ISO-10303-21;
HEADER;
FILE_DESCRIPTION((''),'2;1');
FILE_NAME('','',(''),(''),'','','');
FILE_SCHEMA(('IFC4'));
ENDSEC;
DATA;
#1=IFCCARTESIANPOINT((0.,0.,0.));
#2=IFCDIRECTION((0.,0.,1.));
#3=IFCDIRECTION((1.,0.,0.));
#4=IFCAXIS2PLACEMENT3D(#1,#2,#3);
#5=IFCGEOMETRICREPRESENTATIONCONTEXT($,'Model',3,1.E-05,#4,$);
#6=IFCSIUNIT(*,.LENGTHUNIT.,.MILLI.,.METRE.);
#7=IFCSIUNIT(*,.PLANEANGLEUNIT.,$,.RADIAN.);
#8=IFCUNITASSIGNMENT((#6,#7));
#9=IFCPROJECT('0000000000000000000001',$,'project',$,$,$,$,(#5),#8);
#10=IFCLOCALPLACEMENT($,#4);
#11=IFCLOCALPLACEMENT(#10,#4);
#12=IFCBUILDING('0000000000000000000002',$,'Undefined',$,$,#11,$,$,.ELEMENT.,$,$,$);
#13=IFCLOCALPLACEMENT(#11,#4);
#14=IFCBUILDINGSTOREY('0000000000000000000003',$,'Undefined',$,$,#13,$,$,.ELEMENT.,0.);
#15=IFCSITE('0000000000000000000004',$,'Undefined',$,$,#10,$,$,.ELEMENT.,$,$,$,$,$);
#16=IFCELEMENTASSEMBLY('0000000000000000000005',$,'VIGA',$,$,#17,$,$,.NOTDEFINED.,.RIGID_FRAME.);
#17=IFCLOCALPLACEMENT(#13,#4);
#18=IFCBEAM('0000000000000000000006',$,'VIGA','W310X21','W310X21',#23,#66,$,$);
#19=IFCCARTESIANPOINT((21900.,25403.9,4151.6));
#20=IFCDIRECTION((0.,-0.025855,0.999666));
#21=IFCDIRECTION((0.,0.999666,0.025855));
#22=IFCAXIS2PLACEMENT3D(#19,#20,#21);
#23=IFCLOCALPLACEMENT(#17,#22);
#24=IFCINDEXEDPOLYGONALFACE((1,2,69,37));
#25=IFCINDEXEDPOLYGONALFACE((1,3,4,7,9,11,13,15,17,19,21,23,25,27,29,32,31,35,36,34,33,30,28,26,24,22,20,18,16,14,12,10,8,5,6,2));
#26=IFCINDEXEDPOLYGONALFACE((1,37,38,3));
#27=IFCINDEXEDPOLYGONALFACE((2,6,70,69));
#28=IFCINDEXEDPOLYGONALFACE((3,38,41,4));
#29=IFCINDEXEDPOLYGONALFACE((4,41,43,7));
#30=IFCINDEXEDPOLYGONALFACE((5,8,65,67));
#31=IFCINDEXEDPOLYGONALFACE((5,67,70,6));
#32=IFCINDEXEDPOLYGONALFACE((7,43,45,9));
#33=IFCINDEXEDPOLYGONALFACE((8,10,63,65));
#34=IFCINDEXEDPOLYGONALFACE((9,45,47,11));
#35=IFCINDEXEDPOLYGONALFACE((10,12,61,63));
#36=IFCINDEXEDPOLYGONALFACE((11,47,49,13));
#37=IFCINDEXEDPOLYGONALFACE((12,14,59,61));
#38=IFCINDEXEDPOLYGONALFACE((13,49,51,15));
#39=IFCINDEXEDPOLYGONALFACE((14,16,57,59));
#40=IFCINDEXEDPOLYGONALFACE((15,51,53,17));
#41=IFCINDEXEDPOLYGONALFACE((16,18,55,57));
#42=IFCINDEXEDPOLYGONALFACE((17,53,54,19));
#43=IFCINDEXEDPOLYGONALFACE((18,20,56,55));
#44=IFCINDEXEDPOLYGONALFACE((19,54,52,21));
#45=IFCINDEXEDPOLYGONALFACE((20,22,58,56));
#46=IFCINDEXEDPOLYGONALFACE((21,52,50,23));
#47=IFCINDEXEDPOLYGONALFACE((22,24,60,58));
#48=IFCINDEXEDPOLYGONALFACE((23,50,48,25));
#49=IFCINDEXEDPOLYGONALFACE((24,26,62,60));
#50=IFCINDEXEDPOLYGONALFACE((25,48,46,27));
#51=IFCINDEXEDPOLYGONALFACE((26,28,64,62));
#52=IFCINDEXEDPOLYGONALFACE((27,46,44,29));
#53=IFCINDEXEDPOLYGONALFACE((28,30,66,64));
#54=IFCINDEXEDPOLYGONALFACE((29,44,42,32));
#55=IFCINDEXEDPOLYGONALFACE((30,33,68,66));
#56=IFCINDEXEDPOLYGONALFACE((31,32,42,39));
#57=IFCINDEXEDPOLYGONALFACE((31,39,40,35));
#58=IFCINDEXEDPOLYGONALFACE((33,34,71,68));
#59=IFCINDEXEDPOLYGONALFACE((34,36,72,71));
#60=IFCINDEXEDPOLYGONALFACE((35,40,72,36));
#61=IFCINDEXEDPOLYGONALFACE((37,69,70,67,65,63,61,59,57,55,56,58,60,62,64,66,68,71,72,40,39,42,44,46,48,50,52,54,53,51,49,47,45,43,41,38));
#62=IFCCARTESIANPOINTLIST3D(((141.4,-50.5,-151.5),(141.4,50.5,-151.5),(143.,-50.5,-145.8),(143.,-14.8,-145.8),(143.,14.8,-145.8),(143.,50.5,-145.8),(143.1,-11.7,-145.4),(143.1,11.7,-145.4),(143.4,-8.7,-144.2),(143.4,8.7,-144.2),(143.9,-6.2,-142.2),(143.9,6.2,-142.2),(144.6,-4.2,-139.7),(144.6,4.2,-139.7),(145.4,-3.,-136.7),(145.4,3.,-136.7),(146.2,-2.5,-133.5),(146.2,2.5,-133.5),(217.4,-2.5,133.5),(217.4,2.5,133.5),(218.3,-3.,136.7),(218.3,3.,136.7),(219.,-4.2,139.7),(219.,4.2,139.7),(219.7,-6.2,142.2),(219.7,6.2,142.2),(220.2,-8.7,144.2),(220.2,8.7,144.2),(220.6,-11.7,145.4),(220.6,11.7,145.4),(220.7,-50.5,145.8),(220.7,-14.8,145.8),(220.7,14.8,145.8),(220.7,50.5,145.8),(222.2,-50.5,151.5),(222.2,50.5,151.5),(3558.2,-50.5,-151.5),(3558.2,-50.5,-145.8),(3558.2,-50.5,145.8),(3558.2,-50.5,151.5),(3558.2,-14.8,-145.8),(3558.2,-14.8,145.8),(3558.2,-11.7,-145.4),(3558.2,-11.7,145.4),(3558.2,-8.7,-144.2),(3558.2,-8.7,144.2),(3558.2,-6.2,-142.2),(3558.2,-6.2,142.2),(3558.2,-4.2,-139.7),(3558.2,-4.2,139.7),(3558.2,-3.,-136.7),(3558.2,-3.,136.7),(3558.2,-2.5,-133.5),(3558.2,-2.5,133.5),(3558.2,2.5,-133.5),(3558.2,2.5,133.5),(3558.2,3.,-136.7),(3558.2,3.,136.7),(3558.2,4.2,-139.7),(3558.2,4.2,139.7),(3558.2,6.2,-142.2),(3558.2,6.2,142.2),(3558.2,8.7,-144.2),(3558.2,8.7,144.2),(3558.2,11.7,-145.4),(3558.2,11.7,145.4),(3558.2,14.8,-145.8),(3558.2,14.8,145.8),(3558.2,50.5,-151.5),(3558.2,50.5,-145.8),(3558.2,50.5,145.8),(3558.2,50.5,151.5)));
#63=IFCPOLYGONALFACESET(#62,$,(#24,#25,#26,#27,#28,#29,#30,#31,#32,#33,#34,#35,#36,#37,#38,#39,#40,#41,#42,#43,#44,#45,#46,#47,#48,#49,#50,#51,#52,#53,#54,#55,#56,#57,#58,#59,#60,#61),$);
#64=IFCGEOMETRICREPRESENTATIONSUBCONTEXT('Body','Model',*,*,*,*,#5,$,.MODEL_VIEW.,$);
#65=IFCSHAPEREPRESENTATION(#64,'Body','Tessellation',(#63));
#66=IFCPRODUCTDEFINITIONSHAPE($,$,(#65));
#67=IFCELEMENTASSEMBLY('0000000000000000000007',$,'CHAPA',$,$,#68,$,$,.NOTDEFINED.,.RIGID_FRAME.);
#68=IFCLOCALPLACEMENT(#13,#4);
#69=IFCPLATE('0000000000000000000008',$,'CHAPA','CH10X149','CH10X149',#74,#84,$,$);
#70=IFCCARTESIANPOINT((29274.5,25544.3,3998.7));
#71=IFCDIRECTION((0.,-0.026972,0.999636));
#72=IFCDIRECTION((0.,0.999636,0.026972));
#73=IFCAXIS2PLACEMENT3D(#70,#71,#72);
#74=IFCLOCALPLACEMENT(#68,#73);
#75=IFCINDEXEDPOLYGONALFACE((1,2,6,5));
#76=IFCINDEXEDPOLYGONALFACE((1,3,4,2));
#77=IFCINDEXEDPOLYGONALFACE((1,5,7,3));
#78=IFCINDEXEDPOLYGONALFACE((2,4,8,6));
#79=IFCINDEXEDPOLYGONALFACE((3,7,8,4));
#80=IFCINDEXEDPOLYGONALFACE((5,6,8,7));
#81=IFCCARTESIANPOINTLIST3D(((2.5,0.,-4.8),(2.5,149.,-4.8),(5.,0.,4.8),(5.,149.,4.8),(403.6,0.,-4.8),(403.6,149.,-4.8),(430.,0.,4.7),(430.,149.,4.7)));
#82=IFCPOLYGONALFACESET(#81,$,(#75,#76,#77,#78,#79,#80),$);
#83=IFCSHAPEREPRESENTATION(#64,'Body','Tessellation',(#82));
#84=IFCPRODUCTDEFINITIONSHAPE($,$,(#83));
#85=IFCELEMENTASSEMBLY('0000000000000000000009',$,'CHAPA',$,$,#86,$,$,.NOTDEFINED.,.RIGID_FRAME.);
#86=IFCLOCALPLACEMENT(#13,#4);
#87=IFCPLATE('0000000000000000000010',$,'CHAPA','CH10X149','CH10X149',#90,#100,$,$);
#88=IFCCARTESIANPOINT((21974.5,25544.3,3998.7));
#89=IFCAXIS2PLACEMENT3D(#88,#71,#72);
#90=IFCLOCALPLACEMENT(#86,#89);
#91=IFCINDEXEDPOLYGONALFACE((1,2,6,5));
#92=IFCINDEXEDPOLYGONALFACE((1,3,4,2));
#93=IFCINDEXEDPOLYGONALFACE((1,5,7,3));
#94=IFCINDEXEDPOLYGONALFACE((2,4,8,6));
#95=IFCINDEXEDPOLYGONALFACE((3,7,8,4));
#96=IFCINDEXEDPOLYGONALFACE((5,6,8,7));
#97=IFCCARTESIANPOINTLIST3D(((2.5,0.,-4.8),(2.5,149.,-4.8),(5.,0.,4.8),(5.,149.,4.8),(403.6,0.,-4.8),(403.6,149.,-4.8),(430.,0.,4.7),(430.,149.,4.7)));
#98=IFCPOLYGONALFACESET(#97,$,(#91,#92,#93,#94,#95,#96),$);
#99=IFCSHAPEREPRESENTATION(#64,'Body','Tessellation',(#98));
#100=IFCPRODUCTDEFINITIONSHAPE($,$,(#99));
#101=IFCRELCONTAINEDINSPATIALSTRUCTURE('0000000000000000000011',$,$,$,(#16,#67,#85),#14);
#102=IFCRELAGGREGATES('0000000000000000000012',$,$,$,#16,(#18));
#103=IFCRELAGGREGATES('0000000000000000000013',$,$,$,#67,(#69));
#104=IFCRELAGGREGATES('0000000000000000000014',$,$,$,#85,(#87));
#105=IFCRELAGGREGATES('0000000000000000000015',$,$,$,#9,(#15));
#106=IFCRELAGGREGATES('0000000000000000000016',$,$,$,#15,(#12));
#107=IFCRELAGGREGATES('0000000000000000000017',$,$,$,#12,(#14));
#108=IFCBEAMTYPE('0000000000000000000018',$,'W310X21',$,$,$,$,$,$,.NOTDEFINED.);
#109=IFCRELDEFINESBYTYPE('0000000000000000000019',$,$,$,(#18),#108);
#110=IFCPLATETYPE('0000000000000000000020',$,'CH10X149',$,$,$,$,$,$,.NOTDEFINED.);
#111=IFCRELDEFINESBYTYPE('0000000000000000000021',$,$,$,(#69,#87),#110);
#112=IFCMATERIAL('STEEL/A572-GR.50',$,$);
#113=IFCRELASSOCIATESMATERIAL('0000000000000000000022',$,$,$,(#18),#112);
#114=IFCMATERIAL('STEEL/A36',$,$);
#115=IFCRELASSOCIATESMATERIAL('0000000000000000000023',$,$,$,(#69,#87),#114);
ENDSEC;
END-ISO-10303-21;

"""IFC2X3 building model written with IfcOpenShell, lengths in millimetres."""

from ifc_helpers import new_model, si_unit, frame, origin_with_axes, origin_2d_with_axis, place, context, subcontext, project, spatial, polyline, i_section, outline, extrude, clip, halfspace, material, type_object, element, aggregate, save


model = new_model("IFC2X3")

# Units and contexts
model_context = context("Model", 3, precision=1e-05, world=origin_with_axes())
body_context = subcontext(model_context, "Body", "Model", "MODEL_VIEW")
ifc_project = project(units=[si_unit("LENGTHUNIT", "METRE", prefix="MILLI"), si_unit("PLANEANGLEUNIT", "RADIAN")], contexts=[model_context])

# Site, building, storey
site_placement = place(None, origin_with_axes())
site = spatial("IfcSite", under=ifc_project, at=site_placement, Name="Undefined", CompositionType="ELEMENT")
building_placement = place(site_placement, origin_with_axes())
building = spatial("IfcBuilding", under=site, at=building_placement, Name="Undefined", CompositionType="ELEMENT")
storey_placement = place(building_placement, origin_with_axes())
storey = spatial("IfcBuildingStorey", under=building, at=storey_placement, Name="Undefined", CompositionType="ELEMENT", Elevation=0.0)

# Element assembly, beam
ifc_material_1 = material(Name="STEEL/A572-GR.50")
beam_type_1 = type_object("IfcBeamType", Name="W310X21", PredefinedType="NOTDEFINED")
assembly_1_placement = place(storey_placement, origin_with_axes())
assembly_1 = element("IfcElementAssembly", 1, at=assembly_1_placement, inside=storey, Name="VIGA", AssemblyPlace="NOTDEFINED", PredefinedType="RIGID_FRAME")
beam_1_placement = place(assembly_1_placement, frame((21900.0, 25403.9, 4151.6), z_axis=(0.0, -0.025855, 0.999666), x_axis=(0.0, 0.999666, 0.025855)))
beam_1 = element("IfcBeam", 2, at=beam_1_placement, type_object=beam_type_1, material=ifc_material_1, Name="VIGA", Description="W310X21", ObjectType="W310X21", context=body_context, shape_type="Clipping", body=[
    clip(extrude(i_section(OverallWidth=101.0, OverallDepth=303.0, WebThickness=5.1, FlangeThickness=5.7, FilletRadius=12.3, at=origin_2d_with_axis()), frame((3558.2, 0.0, 0.0), z_axis=(-1.0, 0.0, 0.0), x_axis=(0.0, -1.0, 0.0)), (0.0, 0.0, 1.0), 3558.2), halfspace(frame((141.4, -50.5, -151.7), z_axis=(-0.966259, 0.0, 0.257573), x_axis=(0.0, 1.0, 0.0)), False)),
])
aggregate(assembly_1, [beam_1])

# Shared definitions
ifc_material_2 = material(Name="STEEL/A36")

# Element assemblies, plates
plate_type_1 = type_object("IfcPlateType", Name="CH10X149", PredefinedType="NOTDEFINED")
assembly_2_placement = place(storey_placement, origin_with_axes())
assembly_2 = element("IfcElementAssembly", 3, at=assembly_2_placement, inside=storey, Name="CHAPA", AssemblyPlace="NOTDEFINED", PredefinedType="RIGID_FRAME")
plate_1_placement = place(assembly_2_placement, frame((29274.5, 25544.3, 3998.7), z_axis=(0.0, -0.026972, 0.999636), x_axis=(0.0, 0.999636, 0.026972)))
plate_1 = element("IfcPlate", 4, at=plate_1_placement, type_object=plate_type_1, material=ifc_material_2, Name="CHAPA", Description="CH10X149", ObjectType="CH10X149", context=body_context, shape_type="Clipping", body=[
    clip(clip(extrude(outline(polyline([(0.0, 0.0), (430.0, 0.0), (430.0, 149.0), (0.0, 149.0), (0.0, 0.0)])), frame((0.0, 0.0, -4.8), z_axis=(0.0, 0.0, 1.0), x_axis=(1.0, 0.0, 0.0)), (0.0, 0.0, 1.0), 9.5), halfspace(frame((403.6, -500.0, -4.8), z_axis=(0.33881, 0.0, -0.940855), x_axis=(0.940855, 0.0, 0.33881)), False)), halfspace(frame((5.0, -500.0, 4.7), z_axis=(-0.965989, 0.0, 0.258583), x_axis=(-0.258583, 0.0, -0.965989)), False)),
])
aggregate(assembly_2, [plate_1])
assembly_3_placement = place(storey_placement, origin_with_axes())
assembly_3 = element("IfcElementAssembly", 5, at=assembly_3_placement, inside=storey, Name="CHAPA", AssemblyPlace="NOTDEFINED", PredefinedType="RIGID_FRAME")
plate_2_placement = place(assembly_3_placement, frame((21974.5, 25544.3, 3998.7), z_axis=(0.0, -0.026972, 0.999636), x_axis=(0.0, 0.999636, 0.026972)))
plate_2 = element("IfcPlate", 6, at=plate_2_placement, type_object=plate_type_1, material=ifc_material_2, Name="CHAPA", Description="CH10X149", ObjectType="CH10X149", context=body_context, shape_type="Clipping", body=[
    clip(clip(extrude(outline(polyline([(0.0, 0.0), (430.0, 0.0), (430.0, 149.0), (0.0, 149.0), (0.0, 0.0)])), frame((0.0, 0.0, -4.8), z_axis=(0.0, 0.0, 1.0), x_axis=(1.0, 0.0, 0.0)), (0.0, 0.0, 1.0), 9.5), halfspace(frame((403.6, -500.0, -4.8), z_axis=(0.33881, 0.0, -0.940855), x_axis=(0.940855, 0.0, 0.33881)), False)), halfspace(frame((5.0, -500.0, 4.7), z_axis=(-0.965989, 0.0, 0.258583), x_axis=(-0.258583, 0.0, -0.965989)), False)),
])
aggregate(assembly_3, [plate_2])

save(model, "model.ifc")
